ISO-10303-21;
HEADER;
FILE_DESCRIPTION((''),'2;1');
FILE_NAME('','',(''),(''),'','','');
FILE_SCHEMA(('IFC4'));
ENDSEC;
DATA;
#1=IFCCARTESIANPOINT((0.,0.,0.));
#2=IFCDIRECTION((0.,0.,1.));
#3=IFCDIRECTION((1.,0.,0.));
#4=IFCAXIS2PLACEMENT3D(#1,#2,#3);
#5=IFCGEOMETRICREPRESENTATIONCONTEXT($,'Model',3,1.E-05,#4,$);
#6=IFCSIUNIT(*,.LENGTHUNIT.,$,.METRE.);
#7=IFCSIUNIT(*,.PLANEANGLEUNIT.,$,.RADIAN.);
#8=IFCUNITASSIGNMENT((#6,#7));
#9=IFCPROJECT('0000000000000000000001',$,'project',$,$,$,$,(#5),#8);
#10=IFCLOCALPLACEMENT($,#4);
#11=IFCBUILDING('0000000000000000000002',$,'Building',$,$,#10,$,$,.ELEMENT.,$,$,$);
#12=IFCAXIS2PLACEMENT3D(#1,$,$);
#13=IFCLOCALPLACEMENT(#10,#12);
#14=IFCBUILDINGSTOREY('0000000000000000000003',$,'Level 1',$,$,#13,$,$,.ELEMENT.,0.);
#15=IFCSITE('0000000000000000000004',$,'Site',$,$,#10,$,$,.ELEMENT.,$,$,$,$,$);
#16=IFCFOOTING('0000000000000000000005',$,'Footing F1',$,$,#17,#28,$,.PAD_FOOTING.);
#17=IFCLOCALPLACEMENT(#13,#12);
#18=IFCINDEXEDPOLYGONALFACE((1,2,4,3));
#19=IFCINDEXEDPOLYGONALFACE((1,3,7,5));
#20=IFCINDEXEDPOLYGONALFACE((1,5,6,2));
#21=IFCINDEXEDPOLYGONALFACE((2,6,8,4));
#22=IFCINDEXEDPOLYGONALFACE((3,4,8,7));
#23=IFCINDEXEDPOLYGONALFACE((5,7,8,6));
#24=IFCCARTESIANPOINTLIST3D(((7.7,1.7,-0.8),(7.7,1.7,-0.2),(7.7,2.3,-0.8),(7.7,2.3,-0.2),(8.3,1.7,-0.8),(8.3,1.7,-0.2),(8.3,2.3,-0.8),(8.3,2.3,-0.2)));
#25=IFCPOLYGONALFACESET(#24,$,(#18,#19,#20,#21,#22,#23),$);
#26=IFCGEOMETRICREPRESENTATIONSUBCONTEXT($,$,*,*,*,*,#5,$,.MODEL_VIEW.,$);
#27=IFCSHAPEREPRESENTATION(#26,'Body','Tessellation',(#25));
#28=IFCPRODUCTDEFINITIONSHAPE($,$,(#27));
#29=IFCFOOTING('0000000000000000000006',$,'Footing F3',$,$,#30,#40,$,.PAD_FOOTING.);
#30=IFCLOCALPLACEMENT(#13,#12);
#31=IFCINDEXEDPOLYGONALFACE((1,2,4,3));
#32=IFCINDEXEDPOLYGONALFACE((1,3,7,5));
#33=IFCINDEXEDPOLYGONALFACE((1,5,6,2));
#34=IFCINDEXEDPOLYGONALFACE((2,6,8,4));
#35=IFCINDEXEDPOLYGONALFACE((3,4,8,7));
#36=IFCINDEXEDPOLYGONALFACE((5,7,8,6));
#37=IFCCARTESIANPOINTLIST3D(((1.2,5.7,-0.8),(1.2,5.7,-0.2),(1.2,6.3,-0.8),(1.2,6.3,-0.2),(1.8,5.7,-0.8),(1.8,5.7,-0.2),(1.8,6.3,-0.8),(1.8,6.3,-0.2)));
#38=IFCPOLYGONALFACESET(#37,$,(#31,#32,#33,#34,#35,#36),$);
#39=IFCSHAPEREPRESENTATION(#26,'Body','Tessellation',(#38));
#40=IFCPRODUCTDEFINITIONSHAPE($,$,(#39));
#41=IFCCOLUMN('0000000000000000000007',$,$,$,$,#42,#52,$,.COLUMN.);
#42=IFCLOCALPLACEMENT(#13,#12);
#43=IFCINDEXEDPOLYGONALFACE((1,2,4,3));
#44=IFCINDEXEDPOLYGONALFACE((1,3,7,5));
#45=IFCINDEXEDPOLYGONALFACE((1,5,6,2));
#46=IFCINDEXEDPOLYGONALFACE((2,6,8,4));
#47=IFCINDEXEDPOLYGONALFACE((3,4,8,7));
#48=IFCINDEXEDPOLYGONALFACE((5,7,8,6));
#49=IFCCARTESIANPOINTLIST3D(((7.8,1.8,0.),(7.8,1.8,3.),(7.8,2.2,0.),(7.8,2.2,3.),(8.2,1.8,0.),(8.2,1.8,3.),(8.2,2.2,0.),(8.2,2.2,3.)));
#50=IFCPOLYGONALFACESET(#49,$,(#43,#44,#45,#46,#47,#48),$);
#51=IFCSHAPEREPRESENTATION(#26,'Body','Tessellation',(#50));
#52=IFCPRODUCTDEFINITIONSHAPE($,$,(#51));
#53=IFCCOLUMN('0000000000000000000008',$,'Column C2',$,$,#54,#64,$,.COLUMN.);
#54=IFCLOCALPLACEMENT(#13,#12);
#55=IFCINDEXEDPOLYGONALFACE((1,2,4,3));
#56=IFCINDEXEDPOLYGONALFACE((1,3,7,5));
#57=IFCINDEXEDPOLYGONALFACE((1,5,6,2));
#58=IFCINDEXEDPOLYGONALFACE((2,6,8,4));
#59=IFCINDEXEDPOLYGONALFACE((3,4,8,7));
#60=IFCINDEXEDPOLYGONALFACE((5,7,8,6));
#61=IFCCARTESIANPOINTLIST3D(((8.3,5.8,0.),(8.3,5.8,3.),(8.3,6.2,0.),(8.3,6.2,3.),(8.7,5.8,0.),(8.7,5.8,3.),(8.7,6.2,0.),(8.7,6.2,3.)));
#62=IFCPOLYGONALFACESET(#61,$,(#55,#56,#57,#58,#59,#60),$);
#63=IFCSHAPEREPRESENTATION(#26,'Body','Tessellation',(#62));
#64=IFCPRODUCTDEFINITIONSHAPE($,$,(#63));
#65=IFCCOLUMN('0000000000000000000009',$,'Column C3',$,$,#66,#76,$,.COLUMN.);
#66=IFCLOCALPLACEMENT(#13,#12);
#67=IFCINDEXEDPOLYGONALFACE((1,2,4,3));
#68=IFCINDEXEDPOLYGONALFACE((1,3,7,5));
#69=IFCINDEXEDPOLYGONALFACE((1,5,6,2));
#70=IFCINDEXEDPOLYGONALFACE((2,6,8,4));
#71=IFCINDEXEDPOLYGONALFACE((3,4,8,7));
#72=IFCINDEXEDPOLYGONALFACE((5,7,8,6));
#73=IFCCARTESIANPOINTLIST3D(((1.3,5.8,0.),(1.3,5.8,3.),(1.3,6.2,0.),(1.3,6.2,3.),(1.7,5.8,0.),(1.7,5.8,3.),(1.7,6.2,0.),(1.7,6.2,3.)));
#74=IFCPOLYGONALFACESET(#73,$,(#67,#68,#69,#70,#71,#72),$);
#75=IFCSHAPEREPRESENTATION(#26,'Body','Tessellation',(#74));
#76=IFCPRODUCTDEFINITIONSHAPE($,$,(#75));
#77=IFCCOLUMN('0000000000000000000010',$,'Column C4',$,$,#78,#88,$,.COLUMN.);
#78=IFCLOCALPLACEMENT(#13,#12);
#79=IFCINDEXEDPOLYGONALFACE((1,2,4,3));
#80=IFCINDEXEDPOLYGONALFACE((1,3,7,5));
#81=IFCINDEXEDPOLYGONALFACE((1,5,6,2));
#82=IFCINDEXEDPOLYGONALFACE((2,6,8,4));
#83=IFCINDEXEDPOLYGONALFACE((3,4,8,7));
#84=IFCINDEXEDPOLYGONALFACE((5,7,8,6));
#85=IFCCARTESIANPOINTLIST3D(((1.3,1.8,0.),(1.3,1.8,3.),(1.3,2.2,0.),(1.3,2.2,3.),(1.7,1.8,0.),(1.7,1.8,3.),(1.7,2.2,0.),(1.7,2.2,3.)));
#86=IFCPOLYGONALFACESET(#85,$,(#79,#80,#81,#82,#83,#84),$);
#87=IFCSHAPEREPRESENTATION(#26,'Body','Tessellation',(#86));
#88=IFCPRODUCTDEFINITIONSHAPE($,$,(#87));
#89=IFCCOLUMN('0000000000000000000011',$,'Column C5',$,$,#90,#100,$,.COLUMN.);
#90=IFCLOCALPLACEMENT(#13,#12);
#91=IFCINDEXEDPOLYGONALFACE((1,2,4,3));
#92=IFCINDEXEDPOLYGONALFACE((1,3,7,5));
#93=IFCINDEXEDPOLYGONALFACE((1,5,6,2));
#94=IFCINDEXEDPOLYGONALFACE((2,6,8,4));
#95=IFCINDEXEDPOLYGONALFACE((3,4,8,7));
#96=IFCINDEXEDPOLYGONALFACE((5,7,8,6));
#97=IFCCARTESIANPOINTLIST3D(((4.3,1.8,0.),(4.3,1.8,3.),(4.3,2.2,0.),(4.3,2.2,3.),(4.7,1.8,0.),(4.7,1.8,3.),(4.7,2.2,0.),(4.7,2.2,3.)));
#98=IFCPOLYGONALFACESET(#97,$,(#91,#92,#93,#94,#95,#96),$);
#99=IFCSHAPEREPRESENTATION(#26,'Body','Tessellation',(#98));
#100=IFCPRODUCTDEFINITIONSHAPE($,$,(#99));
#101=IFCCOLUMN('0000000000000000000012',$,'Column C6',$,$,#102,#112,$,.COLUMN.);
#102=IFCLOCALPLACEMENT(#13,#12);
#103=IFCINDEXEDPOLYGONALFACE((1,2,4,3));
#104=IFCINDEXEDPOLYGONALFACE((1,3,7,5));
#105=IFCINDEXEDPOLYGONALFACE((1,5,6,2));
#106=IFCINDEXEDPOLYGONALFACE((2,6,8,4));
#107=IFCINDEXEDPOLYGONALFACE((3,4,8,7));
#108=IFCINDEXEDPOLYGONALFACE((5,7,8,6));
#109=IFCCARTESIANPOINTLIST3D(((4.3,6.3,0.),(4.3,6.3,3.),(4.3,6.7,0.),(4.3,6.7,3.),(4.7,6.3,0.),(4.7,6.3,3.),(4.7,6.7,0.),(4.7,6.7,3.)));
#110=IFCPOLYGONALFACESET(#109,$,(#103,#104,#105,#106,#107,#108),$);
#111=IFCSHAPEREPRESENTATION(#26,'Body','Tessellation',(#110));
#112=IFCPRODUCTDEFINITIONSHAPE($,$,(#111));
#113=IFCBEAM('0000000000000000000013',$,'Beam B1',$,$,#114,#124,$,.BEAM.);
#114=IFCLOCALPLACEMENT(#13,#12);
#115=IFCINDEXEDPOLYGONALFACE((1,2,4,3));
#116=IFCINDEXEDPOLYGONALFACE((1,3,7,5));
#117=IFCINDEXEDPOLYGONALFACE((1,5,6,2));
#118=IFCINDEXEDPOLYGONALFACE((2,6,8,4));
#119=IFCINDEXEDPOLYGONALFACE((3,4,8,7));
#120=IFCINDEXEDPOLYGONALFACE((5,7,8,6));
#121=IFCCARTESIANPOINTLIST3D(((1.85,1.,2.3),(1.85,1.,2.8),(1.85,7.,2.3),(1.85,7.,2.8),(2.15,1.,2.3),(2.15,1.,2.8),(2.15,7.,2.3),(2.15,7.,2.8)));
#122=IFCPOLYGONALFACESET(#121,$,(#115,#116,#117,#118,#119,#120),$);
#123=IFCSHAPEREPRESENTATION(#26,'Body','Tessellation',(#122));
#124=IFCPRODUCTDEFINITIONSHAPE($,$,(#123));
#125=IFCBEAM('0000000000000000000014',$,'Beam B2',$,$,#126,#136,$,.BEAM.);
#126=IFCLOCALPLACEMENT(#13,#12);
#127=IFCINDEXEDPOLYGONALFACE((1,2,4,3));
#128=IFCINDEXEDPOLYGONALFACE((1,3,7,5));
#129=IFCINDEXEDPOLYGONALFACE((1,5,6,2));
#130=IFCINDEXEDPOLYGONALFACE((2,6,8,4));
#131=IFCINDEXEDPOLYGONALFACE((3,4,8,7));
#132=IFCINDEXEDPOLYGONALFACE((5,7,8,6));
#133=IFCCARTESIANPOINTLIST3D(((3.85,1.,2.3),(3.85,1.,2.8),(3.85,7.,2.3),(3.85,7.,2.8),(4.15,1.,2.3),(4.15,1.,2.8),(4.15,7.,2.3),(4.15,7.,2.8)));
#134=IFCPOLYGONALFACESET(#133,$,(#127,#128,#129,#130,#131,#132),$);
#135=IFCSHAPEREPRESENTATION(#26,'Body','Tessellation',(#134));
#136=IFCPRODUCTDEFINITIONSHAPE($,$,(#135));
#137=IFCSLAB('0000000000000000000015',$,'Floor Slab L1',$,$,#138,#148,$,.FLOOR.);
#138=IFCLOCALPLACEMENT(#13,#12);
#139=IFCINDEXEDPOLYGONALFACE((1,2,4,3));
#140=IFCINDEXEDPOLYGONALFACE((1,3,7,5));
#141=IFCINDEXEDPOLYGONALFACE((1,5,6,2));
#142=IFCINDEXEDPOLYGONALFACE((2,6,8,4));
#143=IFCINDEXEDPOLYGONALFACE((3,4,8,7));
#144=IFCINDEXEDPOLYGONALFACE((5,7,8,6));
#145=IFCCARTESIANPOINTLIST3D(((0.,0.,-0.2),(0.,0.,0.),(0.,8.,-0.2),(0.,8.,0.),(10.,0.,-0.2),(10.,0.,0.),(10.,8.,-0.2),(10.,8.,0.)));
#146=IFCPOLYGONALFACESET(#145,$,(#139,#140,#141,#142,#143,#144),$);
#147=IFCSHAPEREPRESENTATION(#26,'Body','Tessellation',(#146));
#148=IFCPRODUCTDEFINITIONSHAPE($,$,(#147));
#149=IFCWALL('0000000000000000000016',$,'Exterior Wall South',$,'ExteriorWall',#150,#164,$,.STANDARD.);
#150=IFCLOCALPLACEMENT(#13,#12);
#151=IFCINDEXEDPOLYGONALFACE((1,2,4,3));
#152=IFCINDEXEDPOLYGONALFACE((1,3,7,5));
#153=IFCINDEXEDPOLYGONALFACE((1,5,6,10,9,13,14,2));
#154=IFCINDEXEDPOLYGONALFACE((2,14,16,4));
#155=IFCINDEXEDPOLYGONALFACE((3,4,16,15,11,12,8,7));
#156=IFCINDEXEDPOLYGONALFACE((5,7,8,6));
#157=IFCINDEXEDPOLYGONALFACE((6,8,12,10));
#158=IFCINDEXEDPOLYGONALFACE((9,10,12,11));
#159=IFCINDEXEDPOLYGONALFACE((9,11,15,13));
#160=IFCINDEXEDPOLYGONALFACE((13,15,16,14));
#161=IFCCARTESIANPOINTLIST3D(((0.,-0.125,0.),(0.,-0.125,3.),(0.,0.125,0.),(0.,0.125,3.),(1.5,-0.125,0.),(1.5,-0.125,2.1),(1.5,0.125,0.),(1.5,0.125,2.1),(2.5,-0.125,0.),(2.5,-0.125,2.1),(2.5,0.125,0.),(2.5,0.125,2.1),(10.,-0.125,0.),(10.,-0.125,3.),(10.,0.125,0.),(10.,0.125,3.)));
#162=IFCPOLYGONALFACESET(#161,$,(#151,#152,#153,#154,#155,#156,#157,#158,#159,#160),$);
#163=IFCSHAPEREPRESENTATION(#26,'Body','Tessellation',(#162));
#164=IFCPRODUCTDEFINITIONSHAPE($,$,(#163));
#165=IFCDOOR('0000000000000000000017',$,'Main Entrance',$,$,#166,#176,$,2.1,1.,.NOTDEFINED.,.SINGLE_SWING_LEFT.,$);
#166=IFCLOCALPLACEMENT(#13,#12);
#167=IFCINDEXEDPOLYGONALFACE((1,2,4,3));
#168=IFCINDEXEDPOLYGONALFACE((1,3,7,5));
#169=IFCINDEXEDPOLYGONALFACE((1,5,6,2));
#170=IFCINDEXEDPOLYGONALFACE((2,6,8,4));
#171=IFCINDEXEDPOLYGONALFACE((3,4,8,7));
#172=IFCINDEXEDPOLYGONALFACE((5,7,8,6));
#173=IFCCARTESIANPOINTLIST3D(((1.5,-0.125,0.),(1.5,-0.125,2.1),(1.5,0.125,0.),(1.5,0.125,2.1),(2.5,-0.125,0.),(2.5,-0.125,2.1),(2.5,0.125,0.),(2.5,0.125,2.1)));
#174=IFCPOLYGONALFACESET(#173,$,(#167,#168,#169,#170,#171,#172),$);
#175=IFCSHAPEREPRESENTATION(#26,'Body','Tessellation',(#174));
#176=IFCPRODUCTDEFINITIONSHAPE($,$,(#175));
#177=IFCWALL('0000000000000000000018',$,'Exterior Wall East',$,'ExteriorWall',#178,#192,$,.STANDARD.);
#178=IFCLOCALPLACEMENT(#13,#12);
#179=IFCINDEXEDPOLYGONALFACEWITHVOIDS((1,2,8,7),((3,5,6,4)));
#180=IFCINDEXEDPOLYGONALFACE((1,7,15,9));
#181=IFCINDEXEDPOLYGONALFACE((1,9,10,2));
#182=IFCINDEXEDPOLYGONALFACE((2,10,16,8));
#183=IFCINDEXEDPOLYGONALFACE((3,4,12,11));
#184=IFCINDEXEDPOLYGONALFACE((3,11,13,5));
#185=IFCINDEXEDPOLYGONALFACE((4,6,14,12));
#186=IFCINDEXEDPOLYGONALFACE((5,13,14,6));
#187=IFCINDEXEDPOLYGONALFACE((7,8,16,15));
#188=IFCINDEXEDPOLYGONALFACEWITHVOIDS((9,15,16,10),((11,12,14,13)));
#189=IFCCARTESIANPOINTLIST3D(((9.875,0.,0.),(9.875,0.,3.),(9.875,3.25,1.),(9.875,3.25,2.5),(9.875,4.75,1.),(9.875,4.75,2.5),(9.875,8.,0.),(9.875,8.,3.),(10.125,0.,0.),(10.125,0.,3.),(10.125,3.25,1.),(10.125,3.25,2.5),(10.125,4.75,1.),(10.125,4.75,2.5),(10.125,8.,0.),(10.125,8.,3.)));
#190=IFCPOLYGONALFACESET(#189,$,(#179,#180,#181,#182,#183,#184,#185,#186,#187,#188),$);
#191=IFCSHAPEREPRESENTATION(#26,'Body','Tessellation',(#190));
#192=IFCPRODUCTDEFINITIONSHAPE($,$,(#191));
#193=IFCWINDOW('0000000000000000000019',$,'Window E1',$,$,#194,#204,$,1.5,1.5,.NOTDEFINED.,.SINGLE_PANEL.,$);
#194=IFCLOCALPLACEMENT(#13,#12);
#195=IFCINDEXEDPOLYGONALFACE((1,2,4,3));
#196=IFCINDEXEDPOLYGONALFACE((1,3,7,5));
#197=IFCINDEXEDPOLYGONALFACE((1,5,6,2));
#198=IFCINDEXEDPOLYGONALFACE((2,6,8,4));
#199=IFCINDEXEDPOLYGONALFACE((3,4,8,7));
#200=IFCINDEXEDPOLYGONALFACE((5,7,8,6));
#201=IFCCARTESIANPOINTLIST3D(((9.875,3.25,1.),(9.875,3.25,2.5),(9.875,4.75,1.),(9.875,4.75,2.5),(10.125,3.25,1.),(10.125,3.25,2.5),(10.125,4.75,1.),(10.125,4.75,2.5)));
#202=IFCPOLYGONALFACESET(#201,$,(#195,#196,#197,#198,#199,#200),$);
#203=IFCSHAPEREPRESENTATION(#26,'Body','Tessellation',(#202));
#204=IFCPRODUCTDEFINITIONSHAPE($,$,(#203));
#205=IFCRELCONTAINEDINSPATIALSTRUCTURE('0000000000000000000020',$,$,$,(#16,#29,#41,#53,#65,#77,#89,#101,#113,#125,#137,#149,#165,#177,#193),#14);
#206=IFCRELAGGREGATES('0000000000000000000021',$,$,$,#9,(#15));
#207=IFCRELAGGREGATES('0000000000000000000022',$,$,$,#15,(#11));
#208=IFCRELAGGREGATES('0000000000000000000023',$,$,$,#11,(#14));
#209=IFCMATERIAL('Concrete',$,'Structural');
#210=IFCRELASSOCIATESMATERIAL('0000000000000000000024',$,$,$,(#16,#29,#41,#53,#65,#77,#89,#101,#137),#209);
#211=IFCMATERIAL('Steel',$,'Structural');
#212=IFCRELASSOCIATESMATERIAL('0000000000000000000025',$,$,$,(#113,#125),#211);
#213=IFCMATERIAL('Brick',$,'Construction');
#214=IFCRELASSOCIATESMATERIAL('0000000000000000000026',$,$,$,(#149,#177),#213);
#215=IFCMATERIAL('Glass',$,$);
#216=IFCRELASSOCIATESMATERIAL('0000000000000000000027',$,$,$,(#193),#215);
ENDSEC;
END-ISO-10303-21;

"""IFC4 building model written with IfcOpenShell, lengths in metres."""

from ifc_helpers import new_model, si_unit, frame, frame_2d, origin, origin_with_axes, origin_2d, place, context, subcontext, project, spatial, rectangle, extrude, material, element, fill, save


model = new_model("IFC4")

# Units and contexts
model_context = context("Model", 3, precision=1e-05, world=origin_with_axes())
sub_context = subcontext(model_context, None, None, "MODEL_VIEW")
ifc_project = project(units=[si_unit("LENGTHUNIT", "METRE"), si_unit("PLANEANGLEUNIT", "RADIAN")], contexts=[model_context])

# Site, building, storey
placement = place(None, origin_with_axes())
site = spatial("IfcSite", under=ifc_project, at=placement, Name="Site", CompositionType="ELEMENT")
building = spatial("IfcBuilding", under=site, at=placement, Name="Building", CompositionType="ELEMENT")
storey_placement = place(placement, origin())
storey = spatial("IfcBuildingStorey", under=building, at=storey_placement, Name="Level 1", CompositionType="ELEMENT", Elevation=0.0)

# Footings
ifc_material_1 = material(Name="Concrete", Category="Structural")
for number, where, name in (
    (1, (8.0, 2.0, -0.8), "Footing F1"),
    (2, (1.5, 6.0, -0.8), "Footing F3"),
):
    element("IfcFooting", number, at=place(placement, frame(where)), inside=storey, material=ifc_material_1, Name=name, PredefinedType="PAD_FOOTING", context=sub_context, shape_type="SweptSolid", body=[
        extrude(rectangle(XDim=0.6, YDim=0.6, at=origin_2d()), origin(), (0.0, 0.0, 1.0), 0.6),
    ])

# Columns
column_placement = place(storey_placement, frame((8.0, 2.0, 0.0)))
element("IfcColumn", 3, at=column_placement, inside=storey, material=ifc_material_1, PredefinedType="COLUMN", context=sub_context, shape_type="SweptSolid", body=[
    extrude(rectangle(XDim=0.4, YDim=0.4, at=origin_2d()), origin(), (0.0, 0.0, 1.0), 3.0),
])
for number, where, name in (
    (4, (8.5, 6.0, 0.0), "Column C2"),
    (5, (1.5, 6.0, 0.0), "Column C3"),
    (6, (1.5, 2.0, 0.0), "Column C4"),
    (7, (4.5, 2.0, 0.0), "Column C5"),
    (8, (4.5, 6.5, 0.0), "Column C6"),
):
    element("IfcColumn", number, at=place(storey_placement, frame(where)), inside=storey, material=ifc_material_1, Name=name, PredefinedType="COLUMN", context=sub_context, shape_type="SweptSolid", body=[
        extrude(rectangle(XDim=0.4, YDim=0.4, at=origin_2d()), origin(), (0.0, 0.0, 1.0), 3.0),
    ])

# Beams
ifc_material_2 = material(Name="Steel", Category="Structural")
for number, where, z_axis, x_axis, name in (
    (9, (2.0, 1.0, 2.55), (0.0, 1.0, 0.0), (-1.0, 0.0, 0.0), "Beam B1"),
    (10, (4.0, 1.0, 2.55), (0.0, 1.0, 0.0), (-1.0, 0.0, 0.0), "Beam B2"),
):
    element("IfcBeam", number, at=place(storey_placement, frame(where, z_axis=z_axis, x_axis=x_axis)), inside=storey, material=ifc_material_2, Name=name, PredefinedType="BEAM", context=sub_context, shape_type="SweptSolid", body=[
        extrude(rectangle(XDim=0.3, YDim=0.5, at=origin_2d()), origin(), (0.0, 0.0, 1.0), 6.0),
    ])

# Slab
slab_placement = place(storey_placement, frame((0.0, 0.0, -0.2)))
element("IfcSlab", 11, at=slab_placement, inside=storey, material=ifc_material_1, Name="Floor Slab L1", PredefinedType="FLOOR", context=sub_context, shape_type="SweptSolid", body=[
    extrude(rectangle(XDim=10.0, YDim=8.0, at=frame_2d((5.0, 4.0))), origin(), (0.0, 0.0, 1.0), 0.2),
])

# Wall, opening, door
ifc_material_3 = material(Name="Brick", Category="Construction")
wall_1_placement = place(storey_placement, frame((0.0, 0.0, 0.0), x_axis=(1.0, 0.0, 0.0)))
wall_1 = element("IfcWall", 12, at=wall_1_placement, inside=storey, material=ifc_material_3, Name="Exterior Wall South", ObjectType="ExteriorWall", PredefinedType="STANDARD", context=sub_context, shape_type="SweptSolid", body=[
    extrude(rectangle(XDim=10.0, YDim=0.25, at=frame_2d((5.0, 0.0))), origin(), (0.0, 0.0, 1.0), 3.0),
])
opening_1_placement = place(wall_1_placement, frame((2.0, 0.175, 0.0), z_axis=(0.0, -1.0, 0.0), x_axis=(1.0, 0.0, 0.0)))
opening_1 = element("IfcOpeningElement", 13, at=opening_1_placement, cuts=wall_1, PredefinedType="OPENING", context=sub_context, shape_type="SweptSolid", body=[
    extrude(rectangle(XDim=1.0, YDim=2.1, at=frame_2d((0.0, 1.05))), origin(), (0.0, 0.0, 1.0), 0.35),
])
door_1_placement = place(wall_1_placement, frame((2.0, 0.125, 0.0), z_axis=(0.0, -1.0, 0.0), x_axis=(1.0, 0.0, 0.0)))
door_1 = element("IfcDoor", 14, at=door_1_placement, inside=storey, Name="Main Entrance", OperationType="SINGLE_SWING_LEFT", OverallHeight=2.1, OverallWidth=1.0, PredefinedType="NOTDEFINED", context=sub_context, shape_type="SweptSolid", body=[
    extrude(rectangle(XDim=1.0, YDim=2.1, at=frame_2d((0.0, 1.05))), origin(), (0.0, 0.0, 1.0), 0.25),
])
fill(opening_1, door_1)

# Wall, opening, window
wall_2_placement = place(storey_placement, frame((10.0, 0.0, 0.0), x_axis=(0.0, 1.0, 0.0)))
wall_2 = element("IfcWall", 15, at=wall_2_placement, inside=storey, material=ifc_material_3, Name="Exterior Wall East", ObjectType="ExteriorWall", PredefinedType="STANDARD", context=sub_context, shape_type="SweptSolid", body=[
    extrude(rectangle(XDim=8.0, YDim=0.25, at=frame_2d((4.0, 0.0))), origin(), (0.0, 0.0, 1.0), 3.0),
])
opening_2_placement = place(wall_2_placement, frame((4.0, 0.175, 1.0), z_axis=(0.0, -1.0, 0.0), x_axis=(1.0, 0.0, 0.0)))
opening_2 = element("IfcOpeningElement", 16, at=opening_2_placement, cuts=wall_2, PredefinedType="OPENING", context=sub_context, shape_type="SweptSolid", body=[
    extrude(rectangle(XDim=1.5, YDim=1.5, at=frame_2d((0.0, 0.75))), origin(), (0.0, 0.0, 1.0), 0.35),
])
ifc_material_4 = material(Name="Glass")
window_1_placement = place(wall_2_placement, frame((4.0, 0.125, 1.0), z_axis=(0.0, -1.0, 0.0), x_axis=(1.0, 0.0, 0.0)))
window_1 = element("IfcWindow", 17, at=window_1_placement, inside=storey, material=ifc_material_4, Name="Window E1", OverallHeight=1.5, OverallWidth=1.5, PartitioningType="SINGLE_PANEL", PredefinedType="NOTDEFINED", context=sub_context, shape_type="SweptSolid", body=[
    extrude(rectangle(XDim=1.5, YDim=1.5, at=frame_2d((0.0, 0.75))), origin(), (0.0, 0.0, 1.0), 0.25),
])
fill(opening_2, window_1)

save(model, "model.ifc")
